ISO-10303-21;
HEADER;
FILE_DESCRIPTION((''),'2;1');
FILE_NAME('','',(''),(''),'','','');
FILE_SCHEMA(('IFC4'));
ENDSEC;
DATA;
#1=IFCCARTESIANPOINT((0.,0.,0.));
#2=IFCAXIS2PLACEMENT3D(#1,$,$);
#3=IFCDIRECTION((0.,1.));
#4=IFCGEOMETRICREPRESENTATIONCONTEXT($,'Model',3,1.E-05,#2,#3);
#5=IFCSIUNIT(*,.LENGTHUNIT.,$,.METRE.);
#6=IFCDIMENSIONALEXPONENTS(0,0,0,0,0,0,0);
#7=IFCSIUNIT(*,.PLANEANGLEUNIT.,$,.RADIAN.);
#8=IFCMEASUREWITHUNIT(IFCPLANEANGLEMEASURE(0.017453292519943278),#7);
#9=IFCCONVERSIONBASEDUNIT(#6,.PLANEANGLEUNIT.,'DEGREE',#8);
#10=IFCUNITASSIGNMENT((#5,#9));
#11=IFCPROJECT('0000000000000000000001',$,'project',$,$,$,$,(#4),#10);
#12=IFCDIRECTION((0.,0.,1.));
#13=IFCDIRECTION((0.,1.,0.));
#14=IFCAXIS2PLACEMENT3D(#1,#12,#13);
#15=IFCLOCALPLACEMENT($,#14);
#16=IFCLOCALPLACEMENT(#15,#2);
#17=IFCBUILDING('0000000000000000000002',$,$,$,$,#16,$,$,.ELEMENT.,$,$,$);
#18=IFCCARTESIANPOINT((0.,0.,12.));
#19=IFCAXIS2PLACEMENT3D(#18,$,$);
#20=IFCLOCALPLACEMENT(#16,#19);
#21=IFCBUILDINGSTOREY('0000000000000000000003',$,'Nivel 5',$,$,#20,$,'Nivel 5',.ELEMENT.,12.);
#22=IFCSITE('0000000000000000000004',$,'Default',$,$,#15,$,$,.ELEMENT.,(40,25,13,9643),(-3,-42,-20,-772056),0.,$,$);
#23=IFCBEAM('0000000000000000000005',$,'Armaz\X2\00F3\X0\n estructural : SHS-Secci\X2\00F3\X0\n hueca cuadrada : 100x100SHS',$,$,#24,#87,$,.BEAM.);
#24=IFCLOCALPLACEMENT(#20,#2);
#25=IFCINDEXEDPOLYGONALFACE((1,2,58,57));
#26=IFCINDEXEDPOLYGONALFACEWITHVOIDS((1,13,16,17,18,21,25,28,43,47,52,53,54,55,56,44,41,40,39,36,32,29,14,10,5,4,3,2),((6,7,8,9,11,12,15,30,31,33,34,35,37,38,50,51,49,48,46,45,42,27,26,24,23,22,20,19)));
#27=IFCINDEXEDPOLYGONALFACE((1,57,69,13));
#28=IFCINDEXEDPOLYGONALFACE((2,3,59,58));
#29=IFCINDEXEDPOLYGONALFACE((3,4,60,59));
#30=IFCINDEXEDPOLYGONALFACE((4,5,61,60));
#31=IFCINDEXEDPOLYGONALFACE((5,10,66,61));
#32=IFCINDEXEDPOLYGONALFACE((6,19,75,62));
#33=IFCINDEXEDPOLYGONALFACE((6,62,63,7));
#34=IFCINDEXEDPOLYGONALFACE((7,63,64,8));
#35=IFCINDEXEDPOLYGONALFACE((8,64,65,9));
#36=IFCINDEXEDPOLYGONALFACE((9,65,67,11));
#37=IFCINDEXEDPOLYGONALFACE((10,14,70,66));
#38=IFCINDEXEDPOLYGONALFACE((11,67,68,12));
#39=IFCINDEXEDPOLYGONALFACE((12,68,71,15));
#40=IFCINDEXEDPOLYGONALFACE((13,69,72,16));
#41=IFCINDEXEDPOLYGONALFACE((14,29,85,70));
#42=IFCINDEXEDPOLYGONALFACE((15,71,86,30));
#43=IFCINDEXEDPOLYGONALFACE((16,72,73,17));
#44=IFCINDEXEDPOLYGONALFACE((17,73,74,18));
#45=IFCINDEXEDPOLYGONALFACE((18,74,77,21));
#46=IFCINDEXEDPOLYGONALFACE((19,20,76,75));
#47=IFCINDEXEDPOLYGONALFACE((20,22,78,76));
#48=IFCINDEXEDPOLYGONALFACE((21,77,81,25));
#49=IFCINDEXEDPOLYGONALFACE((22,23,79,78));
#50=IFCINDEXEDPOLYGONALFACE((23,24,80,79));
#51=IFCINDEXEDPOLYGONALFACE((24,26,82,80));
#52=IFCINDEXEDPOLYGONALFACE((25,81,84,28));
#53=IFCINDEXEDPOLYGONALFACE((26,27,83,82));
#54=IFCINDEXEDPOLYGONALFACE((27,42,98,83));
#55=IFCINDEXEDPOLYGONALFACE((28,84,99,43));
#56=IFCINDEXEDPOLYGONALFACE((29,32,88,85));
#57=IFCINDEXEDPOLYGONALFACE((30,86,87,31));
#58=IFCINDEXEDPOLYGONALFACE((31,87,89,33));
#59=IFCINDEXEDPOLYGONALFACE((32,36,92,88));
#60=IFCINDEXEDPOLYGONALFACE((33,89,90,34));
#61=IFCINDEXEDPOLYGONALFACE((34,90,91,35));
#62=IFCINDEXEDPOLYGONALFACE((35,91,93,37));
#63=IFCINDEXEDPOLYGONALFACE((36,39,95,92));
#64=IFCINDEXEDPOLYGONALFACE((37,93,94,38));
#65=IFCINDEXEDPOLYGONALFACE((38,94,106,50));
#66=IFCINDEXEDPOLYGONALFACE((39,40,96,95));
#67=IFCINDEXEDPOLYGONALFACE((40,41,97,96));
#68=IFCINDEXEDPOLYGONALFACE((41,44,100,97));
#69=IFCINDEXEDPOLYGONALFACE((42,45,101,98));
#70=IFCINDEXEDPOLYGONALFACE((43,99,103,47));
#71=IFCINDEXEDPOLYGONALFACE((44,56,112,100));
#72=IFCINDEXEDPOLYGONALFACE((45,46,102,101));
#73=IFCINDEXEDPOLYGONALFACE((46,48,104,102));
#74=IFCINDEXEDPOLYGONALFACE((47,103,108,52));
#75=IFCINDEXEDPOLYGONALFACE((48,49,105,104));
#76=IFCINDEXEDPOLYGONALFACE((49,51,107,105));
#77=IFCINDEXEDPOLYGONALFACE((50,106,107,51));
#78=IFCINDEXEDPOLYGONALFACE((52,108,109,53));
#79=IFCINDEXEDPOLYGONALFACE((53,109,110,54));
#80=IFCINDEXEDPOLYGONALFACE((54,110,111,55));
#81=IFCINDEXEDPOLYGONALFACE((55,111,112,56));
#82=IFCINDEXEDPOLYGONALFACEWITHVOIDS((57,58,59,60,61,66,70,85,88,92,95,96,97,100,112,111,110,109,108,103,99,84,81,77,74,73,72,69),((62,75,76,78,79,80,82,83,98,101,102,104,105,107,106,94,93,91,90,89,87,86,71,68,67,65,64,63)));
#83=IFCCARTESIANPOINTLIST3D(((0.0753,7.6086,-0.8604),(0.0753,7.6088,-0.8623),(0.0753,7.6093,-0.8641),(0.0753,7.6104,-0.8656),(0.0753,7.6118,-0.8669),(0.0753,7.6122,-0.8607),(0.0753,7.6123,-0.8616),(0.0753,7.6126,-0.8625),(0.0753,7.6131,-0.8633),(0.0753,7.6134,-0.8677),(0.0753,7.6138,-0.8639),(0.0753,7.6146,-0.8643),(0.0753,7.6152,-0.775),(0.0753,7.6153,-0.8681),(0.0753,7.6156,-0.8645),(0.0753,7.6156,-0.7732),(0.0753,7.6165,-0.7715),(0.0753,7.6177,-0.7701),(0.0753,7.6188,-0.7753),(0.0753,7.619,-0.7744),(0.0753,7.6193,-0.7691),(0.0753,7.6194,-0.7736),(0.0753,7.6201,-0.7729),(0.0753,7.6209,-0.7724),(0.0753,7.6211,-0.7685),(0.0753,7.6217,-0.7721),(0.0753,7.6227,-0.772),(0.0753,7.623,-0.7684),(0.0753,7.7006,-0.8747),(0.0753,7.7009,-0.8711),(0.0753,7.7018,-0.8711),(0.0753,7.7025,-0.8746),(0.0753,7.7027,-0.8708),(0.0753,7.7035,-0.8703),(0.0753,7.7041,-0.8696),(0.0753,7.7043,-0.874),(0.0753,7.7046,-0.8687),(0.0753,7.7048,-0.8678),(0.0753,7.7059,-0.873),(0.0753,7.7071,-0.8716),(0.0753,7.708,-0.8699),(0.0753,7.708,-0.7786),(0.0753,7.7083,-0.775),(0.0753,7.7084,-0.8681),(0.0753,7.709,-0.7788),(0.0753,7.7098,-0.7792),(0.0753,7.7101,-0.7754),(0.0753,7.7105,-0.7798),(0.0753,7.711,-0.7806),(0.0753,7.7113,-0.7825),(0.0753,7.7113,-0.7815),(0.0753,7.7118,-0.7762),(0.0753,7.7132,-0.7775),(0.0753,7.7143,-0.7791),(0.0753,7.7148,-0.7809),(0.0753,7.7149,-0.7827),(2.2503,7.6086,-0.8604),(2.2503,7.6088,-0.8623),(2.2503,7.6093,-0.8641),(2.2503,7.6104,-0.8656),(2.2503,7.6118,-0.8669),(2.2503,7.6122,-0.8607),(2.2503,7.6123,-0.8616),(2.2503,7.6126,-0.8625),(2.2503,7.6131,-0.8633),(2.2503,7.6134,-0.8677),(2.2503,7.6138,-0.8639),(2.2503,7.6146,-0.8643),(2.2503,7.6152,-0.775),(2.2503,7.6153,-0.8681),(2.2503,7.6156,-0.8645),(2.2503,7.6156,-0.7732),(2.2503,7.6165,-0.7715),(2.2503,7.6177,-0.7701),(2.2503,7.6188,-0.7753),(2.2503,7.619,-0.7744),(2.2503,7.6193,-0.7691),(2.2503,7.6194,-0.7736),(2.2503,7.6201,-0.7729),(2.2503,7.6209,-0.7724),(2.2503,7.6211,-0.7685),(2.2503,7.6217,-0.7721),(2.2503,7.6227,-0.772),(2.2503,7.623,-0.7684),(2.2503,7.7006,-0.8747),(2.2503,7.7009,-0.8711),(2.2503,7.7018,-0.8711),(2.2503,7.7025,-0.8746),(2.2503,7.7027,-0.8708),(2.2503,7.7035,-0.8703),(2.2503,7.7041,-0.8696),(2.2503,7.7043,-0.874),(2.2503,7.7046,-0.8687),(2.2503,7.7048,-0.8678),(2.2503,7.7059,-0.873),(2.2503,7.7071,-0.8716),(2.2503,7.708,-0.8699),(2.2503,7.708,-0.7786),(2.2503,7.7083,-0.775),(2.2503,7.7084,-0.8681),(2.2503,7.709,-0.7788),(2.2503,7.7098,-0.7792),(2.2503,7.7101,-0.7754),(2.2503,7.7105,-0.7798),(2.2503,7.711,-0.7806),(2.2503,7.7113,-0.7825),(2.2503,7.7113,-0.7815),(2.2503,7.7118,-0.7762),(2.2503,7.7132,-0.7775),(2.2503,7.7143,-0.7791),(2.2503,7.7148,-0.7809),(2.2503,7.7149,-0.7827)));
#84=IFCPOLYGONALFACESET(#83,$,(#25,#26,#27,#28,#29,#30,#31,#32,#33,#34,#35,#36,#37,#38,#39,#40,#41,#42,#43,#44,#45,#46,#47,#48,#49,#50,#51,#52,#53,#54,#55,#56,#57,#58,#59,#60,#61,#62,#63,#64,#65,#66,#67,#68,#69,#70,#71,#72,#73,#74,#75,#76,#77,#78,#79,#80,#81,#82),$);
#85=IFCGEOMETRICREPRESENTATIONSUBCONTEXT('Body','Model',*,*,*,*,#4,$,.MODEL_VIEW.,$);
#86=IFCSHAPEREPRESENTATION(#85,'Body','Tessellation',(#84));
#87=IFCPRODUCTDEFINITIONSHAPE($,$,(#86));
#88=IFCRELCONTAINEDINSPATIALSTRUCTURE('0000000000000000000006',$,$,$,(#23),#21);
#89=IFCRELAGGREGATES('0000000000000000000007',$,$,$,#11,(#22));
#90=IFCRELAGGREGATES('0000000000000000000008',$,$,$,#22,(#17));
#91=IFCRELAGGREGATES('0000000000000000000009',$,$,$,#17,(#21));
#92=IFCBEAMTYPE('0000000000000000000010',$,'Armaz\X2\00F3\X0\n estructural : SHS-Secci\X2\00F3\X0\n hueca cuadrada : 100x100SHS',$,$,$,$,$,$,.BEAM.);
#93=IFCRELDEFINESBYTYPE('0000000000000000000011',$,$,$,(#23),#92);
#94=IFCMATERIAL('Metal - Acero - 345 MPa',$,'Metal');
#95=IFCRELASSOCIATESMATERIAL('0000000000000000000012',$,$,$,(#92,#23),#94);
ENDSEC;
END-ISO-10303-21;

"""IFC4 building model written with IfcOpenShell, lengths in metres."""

from ifc_helpers import new_model, entity, si_unit, converted_unit, direction, frame, origin, place, context, subcontext, project, spatial, line, arc, indexed_curve, outline, extrude, source, transform, mapped, material, type_object, type_shapes, element, save


model = new_model("IFC4")

# Units and contexts
model_context = context("Model", 3, precision=1e-05, world=origin(), true_north=direction((0.0, 1.0)))
body_context = subcontext(model_context, "Body", "Model", "MODEL_VIEW")
ifc_project = project(units=[si_unit("LENGTHUNIT", "METRE"), converted_unit("PLANEANGLEUNIT", "DEGREE", entity("IfcPlaneAngleMeasure", 0.017453292519943278), si_unit("PLANEANGLEUNIT", "RADIAN"), dimensions=[0, 0, 0, 0, 0, 0, 0])], contexts=[model_context])

# Site, building, storey
site_placement = place(None, frame((0.0, 0.0, 0.0), z_axis=(0.0, 0.0, 1.0), x_axis=(0.0, 1.0, 0.0)))
site = spatial("IfcSite", under=ifc_project, at=site_placement, Name="Default", CompositionType="ELEMENT", RefLatitude=(40, 25, 13, 9643), RefLongitude=(-3, -42, -20, -772056), RefElevation=0.0)
building_placement = place(site_placement, origin())
building = spatial("IfcBuilding", under=site, at=building_placement, CompositionType="ELEMENT")
storey_placement = place(building_placement, frame((0.0, 0.0, 12.0)))
storey = spatial("IfcBuildingStorey", under=building, at=storey_placement, Name="Nivel 5", LongName="Nivel 5", CompositionType="ELEMENT", Elevation=12.0)

# Beam
ifc_material_1 = material(Name="Metal - Acero - 345 MPa", Category="Metal")
beam_type = type_object("IfcBeamType", Name="Armazón estructural : SHS-Sección hueca cuadrada : 100x100SHS", PredefinedType="BEAM", material=ifc_material_1)
shared_shape = source(origin(), body_context, "Body", "SweptSolid", [
    extrude(outline(indexed_curve([(-0.05, -0.0428), (-0.0479, -0.0479), (-0.0428, -0.05), (0.0428, -0.05), (0.0479, -0.0479), (0.05, -0.0428), (0.05, 0.0428), (0.0479, 0.0479), (0.0428, 0.05), (-0.0428, 0.05), (-0.0479, 0.0479), (-0.05, 0.0428)], segments=[arc(1, 2, 3), line(3, 4), arc(4, 5, 6), line(6, 7), arc(7, 8, 9), line(9, 10), arc(10, 11, 12), line(12, 1)], self_intersect=False), holes=[indexed_curve([(0.0428, -0.0464), (-0.0428, -0.0464), (-0.0453, -0.0453), (-0.0464, -0.0428), (-0.0464, 0.0428), (-0.0453, 0.0453), (-0.0428, 0.0464), (0.0428, 0.0464), (0.0453, 0.0453), (0.0464, 0.0428), (0.0464, -0.0428), (0.0453, -0.0453)], segments=[line(1, 2), arc(2, 3, 4), line(4, 5), arc(5, 6, 7), line(7, 8), arc(8, 9, 10), line(10, 11), arc(11, 12, 1)], self_intersect=False)]), frame((-1.072, 0.0, 0.0), z_axis=(1.0, 0.0, 0.0), x_axis=(0.0, -1.0, 0.0)), (0.0, 0.0, 1.0), 2.175),
])
type_shapes(beam_type, [shared_shape])
beam_placement = place(storey_placement, frame((1.1783, 7.6618, -0.8216), z_axis=(0.0, 0.076893, 0.997039), x_axis=(-1.0, 0.0, 0.0)))
element("IfcBeam", 1, at=beam_placement, inside=storey, type_object=beam_type, material=ifc_material_1, Name="Armazón estructural : SHS-Sección hueca cuadrada : 100x100SHS", PredefinedType="BEAM", context=body_context, shape_type="MappedRepresentation", body=[
    mapped(shared_shape, transform((0.0, 0.0, 0.0), scale=1.0)),
])

save(model, "model.ifc")
